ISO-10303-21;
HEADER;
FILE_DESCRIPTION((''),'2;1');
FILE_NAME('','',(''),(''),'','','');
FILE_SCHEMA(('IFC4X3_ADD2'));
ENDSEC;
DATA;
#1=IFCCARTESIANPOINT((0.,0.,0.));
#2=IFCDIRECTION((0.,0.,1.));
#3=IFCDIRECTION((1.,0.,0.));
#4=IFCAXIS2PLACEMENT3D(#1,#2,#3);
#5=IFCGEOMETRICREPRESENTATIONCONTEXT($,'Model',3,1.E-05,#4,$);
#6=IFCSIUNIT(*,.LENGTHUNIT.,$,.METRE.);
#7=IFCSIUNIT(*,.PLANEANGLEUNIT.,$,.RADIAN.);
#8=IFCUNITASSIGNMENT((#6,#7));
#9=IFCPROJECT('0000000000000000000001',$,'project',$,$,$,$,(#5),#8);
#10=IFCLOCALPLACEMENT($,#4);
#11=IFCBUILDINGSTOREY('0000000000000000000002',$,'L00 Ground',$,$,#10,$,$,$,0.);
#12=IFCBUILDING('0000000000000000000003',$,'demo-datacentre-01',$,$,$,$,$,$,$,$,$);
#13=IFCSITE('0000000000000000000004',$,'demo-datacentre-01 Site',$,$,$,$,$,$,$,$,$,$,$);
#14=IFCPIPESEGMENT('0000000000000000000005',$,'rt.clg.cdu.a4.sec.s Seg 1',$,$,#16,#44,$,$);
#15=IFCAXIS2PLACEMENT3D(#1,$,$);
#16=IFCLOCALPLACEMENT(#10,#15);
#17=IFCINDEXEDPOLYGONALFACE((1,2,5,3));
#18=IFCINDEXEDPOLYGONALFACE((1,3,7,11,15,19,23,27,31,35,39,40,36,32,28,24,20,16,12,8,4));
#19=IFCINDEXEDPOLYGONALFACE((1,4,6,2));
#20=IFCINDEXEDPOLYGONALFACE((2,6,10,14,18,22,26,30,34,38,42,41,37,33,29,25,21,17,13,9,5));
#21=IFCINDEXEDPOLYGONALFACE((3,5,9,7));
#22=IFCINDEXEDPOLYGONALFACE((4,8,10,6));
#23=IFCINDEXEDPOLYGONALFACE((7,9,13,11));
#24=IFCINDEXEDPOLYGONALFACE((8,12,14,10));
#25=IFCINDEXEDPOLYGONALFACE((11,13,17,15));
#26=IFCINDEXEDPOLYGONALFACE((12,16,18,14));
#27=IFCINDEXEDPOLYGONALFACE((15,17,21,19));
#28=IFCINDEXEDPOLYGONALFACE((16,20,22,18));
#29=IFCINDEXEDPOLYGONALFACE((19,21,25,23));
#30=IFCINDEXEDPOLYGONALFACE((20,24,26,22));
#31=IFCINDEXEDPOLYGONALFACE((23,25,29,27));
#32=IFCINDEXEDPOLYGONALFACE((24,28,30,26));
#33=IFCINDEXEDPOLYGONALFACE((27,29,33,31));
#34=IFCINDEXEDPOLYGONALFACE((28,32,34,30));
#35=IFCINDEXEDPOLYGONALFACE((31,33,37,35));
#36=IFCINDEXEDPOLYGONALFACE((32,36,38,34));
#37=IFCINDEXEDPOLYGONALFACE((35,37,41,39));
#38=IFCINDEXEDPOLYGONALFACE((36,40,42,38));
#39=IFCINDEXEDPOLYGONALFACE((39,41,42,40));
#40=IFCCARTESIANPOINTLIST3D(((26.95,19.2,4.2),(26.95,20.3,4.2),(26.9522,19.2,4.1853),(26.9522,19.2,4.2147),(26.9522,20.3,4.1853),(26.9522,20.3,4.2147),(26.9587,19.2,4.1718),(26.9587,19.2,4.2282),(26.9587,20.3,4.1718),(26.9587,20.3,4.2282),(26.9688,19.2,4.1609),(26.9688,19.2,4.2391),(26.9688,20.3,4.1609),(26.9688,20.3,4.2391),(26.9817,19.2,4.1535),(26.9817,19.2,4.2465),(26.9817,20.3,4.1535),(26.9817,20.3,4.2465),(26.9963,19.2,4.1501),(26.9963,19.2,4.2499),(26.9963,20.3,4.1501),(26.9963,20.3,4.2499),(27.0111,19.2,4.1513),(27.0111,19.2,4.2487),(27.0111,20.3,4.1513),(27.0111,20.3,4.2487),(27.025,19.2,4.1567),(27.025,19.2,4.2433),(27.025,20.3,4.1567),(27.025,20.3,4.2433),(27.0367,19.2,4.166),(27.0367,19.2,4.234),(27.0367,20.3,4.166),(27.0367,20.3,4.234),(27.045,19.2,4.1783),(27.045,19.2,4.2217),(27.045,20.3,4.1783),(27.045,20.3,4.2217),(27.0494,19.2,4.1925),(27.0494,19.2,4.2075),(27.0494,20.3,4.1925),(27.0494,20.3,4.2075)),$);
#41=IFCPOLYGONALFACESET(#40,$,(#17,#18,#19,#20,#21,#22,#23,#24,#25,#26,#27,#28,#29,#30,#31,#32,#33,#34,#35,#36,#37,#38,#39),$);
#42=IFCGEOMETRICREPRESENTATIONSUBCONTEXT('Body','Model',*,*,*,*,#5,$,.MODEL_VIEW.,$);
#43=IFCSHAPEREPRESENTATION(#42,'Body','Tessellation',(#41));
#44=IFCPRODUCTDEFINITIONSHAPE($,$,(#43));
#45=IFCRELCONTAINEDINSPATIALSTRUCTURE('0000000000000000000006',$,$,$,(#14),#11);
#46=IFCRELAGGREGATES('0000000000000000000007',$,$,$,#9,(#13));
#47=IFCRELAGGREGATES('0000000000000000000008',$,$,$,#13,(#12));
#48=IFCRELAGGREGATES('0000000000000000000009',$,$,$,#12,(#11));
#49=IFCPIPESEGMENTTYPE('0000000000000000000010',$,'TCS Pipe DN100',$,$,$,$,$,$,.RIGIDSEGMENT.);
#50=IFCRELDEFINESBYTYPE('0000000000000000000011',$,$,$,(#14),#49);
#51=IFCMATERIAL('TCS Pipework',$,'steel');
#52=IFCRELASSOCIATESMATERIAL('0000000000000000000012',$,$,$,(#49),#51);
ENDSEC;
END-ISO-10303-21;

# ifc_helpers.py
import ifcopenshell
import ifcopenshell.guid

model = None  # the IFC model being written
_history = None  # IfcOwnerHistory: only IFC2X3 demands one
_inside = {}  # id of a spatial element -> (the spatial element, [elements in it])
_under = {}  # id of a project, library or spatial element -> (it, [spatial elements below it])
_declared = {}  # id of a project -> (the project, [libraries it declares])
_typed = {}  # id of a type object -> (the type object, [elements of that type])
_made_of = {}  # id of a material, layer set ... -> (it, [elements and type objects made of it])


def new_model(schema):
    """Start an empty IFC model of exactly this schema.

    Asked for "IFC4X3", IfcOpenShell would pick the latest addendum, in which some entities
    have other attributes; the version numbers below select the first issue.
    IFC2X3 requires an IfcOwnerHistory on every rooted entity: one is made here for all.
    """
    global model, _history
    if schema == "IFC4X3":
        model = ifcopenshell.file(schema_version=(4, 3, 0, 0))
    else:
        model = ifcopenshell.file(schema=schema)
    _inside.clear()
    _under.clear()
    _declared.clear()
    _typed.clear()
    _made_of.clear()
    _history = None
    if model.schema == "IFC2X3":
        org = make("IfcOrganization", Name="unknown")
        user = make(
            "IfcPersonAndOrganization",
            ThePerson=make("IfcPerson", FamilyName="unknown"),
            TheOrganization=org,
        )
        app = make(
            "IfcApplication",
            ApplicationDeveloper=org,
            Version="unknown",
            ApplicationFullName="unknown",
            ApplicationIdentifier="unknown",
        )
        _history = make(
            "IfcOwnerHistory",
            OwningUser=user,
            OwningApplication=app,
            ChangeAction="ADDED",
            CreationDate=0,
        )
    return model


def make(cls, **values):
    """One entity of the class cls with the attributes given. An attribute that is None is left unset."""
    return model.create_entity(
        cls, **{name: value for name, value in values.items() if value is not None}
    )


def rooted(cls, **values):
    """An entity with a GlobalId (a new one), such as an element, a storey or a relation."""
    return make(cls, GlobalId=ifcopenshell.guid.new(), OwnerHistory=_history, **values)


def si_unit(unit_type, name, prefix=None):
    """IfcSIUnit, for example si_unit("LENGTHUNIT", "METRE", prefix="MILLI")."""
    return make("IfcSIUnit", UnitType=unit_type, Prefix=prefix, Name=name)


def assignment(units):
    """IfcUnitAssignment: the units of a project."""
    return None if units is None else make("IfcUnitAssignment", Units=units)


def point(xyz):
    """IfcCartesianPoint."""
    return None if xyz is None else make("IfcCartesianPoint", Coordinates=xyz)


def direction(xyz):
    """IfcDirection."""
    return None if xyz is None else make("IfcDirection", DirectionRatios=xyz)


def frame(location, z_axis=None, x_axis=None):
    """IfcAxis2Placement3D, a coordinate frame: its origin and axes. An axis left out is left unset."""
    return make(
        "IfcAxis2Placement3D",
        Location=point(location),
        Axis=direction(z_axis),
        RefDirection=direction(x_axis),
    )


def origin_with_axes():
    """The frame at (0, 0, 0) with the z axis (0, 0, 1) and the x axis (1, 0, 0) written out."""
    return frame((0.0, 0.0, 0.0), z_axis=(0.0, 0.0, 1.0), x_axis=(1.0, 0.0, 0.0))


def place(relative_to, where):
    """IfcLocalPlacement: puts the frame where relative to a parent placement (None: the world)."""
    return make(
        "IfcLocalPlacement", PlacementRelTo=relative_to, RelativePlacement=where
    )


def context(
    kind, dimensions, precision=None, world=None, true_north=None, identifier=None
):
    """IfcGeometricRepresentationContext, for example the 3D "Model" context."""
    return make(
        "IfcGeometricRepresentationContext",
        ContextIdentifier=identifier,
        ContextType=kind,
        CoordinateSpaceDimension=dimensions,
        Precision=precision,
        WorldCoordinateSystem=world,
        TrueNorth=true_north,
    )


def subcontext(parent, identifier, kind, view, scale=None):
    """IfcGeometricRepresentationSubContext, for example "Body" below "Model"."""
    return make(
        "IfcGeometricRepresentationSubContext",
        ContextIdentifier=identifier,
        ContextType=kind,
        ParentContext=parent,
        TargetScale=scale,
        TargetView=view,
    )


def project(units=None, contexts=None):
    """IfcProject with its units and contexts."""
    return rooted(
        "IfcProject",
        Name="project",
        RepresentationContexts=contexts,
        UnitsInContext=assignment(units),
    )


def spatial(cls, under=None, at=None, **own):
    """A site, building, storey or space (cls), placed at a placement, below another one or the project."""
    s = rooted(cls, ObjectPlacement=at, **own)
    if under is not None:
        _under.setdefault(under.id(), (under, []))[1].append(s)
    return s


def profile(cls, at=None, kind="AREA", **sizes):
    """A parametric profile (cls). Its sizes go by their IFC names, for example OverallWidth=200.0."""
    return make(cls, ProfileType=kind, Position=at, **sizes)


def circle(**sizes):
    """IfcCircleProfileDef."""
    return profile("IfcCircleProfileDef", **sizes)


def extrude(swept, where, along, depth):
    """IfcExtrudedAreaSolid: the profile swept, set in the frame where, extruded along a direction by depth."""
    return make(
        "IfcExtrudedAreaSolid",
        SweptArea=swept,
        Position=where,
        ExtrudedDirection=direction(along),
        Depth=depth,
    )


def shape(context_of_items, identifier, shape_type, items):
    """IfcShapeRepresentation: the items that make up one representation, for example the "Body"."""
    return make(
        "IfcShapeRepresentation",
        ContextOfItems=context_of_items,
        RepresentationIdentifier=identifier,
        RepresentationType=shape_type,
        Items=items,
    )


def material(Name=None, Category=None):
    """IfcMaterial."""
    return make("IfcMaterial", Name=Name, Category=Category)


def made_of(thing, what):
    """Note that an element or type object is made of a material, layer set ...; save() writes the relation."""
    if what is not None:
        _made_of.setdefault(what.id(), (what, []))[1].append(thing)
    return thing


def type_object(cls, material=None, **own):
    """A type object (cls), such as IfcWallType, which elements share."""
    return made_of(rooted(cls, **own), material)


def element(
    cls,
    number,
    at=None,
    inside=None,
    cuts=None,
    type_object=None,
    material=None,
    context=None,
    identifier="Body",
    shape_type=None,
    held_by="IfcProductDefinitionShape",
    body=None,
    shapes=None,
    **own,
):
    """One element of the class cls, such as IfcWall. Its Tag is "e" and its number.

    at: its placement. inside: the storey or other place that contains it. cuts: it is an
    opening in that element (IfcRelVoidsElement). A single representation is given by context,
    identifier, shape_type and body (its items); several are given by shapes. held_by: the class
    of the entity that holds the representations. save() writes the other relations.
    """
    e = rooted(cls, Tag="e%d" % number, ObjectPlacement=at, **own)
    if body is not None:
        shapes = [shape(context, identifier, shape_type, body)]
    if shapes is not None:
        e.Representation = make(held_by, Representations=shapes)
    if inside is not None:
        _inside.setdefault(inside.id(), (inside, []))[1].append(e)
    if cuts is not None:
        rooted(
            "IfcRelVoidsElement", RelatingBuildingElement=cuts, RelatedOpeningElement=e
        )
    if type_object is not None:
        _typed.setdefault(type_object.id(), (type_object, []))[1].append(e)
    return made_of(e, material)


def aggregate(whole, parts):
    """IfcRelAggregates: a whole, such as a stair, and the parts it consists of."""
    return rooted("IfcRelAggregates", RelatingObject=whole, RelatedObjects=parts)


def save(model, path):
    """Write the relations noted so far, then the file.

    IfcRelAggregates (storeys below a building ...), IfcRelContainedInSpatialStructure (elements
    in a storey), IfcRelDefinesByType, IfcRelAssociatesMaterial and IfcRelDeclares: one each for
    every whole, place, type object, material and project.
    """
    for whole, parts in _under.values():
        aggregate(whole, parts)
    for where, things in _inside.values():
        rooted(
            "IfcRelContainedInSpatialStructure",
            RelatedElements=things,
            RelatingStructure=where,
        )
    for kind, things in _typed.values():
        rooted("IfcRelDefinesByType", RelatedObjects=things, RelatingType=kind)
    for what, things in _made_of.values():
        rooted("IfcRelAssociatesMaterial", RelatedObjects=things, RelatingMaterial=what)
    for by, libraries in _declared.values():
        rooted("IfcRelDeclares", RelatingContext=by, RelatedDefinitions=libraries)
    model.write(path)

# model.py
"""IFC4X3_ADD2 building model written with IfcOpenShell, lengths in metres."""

from ifc_helpers import new_model, si_unit, frame, origin_with_axes, place, context, subcontext, project, spatial, circle, extrude, material, type_object, element, save


model = new_model("IFC4X3_ADD2")

# Units and contexts
model_context = context("Model", 3, precision=1e-05, world=origin_with_axes())
body_context = subcontext(model_context, "Body", "Model", "MODEL_VIEW")
ifc_project = project(units=[si_unit("LENGTHUNIT", "METRE"), si_unit("PLANEANGLEUNIT", "RADIAN")], contexts=[model_context])

# Site, building, storey
site = spatial("IfcSite", under=ifc_project, Name="demo-datacentre-01 Site")
building = spatial("IfcBuilding", under=site, Name="demo-datacentre-01")
storey_placement = place(None, origin_with_axes())
storey = spatial("IfcBuildingStorey", under=building, at=storey_placement, Name="L00 Ground", Elevation=0.0)

# Pipe segment
ifc_material_1 = material(Name="TCS Pipework", Category="steel")
pipe_segment_type_1 = type_object("IfcPipeSegmentType", Name="TCS Pipe DN100", PredefinedType="RIGIDSEGMENT", material=ifc_material_1)
pipe_segment_1_placement = place(storey_placement, frame((27.0, 19.2, 4.2), z_axis=(0.0, 1.0, 0.0), x_axis=(-1.0, 0.0, 0.0)))
element("IfcPipeSegment", 1, at=pipe_segment_1_placement, inside=storey, type_object=pipe_segment_type_1, Name="rt.clg.cdu.a4.sec.s Seg 1", context=body_context, shape_type="SweptSolid", body=[
    extrude(circle(Radius=0.05), origin_with_axes(), (0.0, 0.0, 1.0), 1.1),
])

save(model, "model.ifc")
